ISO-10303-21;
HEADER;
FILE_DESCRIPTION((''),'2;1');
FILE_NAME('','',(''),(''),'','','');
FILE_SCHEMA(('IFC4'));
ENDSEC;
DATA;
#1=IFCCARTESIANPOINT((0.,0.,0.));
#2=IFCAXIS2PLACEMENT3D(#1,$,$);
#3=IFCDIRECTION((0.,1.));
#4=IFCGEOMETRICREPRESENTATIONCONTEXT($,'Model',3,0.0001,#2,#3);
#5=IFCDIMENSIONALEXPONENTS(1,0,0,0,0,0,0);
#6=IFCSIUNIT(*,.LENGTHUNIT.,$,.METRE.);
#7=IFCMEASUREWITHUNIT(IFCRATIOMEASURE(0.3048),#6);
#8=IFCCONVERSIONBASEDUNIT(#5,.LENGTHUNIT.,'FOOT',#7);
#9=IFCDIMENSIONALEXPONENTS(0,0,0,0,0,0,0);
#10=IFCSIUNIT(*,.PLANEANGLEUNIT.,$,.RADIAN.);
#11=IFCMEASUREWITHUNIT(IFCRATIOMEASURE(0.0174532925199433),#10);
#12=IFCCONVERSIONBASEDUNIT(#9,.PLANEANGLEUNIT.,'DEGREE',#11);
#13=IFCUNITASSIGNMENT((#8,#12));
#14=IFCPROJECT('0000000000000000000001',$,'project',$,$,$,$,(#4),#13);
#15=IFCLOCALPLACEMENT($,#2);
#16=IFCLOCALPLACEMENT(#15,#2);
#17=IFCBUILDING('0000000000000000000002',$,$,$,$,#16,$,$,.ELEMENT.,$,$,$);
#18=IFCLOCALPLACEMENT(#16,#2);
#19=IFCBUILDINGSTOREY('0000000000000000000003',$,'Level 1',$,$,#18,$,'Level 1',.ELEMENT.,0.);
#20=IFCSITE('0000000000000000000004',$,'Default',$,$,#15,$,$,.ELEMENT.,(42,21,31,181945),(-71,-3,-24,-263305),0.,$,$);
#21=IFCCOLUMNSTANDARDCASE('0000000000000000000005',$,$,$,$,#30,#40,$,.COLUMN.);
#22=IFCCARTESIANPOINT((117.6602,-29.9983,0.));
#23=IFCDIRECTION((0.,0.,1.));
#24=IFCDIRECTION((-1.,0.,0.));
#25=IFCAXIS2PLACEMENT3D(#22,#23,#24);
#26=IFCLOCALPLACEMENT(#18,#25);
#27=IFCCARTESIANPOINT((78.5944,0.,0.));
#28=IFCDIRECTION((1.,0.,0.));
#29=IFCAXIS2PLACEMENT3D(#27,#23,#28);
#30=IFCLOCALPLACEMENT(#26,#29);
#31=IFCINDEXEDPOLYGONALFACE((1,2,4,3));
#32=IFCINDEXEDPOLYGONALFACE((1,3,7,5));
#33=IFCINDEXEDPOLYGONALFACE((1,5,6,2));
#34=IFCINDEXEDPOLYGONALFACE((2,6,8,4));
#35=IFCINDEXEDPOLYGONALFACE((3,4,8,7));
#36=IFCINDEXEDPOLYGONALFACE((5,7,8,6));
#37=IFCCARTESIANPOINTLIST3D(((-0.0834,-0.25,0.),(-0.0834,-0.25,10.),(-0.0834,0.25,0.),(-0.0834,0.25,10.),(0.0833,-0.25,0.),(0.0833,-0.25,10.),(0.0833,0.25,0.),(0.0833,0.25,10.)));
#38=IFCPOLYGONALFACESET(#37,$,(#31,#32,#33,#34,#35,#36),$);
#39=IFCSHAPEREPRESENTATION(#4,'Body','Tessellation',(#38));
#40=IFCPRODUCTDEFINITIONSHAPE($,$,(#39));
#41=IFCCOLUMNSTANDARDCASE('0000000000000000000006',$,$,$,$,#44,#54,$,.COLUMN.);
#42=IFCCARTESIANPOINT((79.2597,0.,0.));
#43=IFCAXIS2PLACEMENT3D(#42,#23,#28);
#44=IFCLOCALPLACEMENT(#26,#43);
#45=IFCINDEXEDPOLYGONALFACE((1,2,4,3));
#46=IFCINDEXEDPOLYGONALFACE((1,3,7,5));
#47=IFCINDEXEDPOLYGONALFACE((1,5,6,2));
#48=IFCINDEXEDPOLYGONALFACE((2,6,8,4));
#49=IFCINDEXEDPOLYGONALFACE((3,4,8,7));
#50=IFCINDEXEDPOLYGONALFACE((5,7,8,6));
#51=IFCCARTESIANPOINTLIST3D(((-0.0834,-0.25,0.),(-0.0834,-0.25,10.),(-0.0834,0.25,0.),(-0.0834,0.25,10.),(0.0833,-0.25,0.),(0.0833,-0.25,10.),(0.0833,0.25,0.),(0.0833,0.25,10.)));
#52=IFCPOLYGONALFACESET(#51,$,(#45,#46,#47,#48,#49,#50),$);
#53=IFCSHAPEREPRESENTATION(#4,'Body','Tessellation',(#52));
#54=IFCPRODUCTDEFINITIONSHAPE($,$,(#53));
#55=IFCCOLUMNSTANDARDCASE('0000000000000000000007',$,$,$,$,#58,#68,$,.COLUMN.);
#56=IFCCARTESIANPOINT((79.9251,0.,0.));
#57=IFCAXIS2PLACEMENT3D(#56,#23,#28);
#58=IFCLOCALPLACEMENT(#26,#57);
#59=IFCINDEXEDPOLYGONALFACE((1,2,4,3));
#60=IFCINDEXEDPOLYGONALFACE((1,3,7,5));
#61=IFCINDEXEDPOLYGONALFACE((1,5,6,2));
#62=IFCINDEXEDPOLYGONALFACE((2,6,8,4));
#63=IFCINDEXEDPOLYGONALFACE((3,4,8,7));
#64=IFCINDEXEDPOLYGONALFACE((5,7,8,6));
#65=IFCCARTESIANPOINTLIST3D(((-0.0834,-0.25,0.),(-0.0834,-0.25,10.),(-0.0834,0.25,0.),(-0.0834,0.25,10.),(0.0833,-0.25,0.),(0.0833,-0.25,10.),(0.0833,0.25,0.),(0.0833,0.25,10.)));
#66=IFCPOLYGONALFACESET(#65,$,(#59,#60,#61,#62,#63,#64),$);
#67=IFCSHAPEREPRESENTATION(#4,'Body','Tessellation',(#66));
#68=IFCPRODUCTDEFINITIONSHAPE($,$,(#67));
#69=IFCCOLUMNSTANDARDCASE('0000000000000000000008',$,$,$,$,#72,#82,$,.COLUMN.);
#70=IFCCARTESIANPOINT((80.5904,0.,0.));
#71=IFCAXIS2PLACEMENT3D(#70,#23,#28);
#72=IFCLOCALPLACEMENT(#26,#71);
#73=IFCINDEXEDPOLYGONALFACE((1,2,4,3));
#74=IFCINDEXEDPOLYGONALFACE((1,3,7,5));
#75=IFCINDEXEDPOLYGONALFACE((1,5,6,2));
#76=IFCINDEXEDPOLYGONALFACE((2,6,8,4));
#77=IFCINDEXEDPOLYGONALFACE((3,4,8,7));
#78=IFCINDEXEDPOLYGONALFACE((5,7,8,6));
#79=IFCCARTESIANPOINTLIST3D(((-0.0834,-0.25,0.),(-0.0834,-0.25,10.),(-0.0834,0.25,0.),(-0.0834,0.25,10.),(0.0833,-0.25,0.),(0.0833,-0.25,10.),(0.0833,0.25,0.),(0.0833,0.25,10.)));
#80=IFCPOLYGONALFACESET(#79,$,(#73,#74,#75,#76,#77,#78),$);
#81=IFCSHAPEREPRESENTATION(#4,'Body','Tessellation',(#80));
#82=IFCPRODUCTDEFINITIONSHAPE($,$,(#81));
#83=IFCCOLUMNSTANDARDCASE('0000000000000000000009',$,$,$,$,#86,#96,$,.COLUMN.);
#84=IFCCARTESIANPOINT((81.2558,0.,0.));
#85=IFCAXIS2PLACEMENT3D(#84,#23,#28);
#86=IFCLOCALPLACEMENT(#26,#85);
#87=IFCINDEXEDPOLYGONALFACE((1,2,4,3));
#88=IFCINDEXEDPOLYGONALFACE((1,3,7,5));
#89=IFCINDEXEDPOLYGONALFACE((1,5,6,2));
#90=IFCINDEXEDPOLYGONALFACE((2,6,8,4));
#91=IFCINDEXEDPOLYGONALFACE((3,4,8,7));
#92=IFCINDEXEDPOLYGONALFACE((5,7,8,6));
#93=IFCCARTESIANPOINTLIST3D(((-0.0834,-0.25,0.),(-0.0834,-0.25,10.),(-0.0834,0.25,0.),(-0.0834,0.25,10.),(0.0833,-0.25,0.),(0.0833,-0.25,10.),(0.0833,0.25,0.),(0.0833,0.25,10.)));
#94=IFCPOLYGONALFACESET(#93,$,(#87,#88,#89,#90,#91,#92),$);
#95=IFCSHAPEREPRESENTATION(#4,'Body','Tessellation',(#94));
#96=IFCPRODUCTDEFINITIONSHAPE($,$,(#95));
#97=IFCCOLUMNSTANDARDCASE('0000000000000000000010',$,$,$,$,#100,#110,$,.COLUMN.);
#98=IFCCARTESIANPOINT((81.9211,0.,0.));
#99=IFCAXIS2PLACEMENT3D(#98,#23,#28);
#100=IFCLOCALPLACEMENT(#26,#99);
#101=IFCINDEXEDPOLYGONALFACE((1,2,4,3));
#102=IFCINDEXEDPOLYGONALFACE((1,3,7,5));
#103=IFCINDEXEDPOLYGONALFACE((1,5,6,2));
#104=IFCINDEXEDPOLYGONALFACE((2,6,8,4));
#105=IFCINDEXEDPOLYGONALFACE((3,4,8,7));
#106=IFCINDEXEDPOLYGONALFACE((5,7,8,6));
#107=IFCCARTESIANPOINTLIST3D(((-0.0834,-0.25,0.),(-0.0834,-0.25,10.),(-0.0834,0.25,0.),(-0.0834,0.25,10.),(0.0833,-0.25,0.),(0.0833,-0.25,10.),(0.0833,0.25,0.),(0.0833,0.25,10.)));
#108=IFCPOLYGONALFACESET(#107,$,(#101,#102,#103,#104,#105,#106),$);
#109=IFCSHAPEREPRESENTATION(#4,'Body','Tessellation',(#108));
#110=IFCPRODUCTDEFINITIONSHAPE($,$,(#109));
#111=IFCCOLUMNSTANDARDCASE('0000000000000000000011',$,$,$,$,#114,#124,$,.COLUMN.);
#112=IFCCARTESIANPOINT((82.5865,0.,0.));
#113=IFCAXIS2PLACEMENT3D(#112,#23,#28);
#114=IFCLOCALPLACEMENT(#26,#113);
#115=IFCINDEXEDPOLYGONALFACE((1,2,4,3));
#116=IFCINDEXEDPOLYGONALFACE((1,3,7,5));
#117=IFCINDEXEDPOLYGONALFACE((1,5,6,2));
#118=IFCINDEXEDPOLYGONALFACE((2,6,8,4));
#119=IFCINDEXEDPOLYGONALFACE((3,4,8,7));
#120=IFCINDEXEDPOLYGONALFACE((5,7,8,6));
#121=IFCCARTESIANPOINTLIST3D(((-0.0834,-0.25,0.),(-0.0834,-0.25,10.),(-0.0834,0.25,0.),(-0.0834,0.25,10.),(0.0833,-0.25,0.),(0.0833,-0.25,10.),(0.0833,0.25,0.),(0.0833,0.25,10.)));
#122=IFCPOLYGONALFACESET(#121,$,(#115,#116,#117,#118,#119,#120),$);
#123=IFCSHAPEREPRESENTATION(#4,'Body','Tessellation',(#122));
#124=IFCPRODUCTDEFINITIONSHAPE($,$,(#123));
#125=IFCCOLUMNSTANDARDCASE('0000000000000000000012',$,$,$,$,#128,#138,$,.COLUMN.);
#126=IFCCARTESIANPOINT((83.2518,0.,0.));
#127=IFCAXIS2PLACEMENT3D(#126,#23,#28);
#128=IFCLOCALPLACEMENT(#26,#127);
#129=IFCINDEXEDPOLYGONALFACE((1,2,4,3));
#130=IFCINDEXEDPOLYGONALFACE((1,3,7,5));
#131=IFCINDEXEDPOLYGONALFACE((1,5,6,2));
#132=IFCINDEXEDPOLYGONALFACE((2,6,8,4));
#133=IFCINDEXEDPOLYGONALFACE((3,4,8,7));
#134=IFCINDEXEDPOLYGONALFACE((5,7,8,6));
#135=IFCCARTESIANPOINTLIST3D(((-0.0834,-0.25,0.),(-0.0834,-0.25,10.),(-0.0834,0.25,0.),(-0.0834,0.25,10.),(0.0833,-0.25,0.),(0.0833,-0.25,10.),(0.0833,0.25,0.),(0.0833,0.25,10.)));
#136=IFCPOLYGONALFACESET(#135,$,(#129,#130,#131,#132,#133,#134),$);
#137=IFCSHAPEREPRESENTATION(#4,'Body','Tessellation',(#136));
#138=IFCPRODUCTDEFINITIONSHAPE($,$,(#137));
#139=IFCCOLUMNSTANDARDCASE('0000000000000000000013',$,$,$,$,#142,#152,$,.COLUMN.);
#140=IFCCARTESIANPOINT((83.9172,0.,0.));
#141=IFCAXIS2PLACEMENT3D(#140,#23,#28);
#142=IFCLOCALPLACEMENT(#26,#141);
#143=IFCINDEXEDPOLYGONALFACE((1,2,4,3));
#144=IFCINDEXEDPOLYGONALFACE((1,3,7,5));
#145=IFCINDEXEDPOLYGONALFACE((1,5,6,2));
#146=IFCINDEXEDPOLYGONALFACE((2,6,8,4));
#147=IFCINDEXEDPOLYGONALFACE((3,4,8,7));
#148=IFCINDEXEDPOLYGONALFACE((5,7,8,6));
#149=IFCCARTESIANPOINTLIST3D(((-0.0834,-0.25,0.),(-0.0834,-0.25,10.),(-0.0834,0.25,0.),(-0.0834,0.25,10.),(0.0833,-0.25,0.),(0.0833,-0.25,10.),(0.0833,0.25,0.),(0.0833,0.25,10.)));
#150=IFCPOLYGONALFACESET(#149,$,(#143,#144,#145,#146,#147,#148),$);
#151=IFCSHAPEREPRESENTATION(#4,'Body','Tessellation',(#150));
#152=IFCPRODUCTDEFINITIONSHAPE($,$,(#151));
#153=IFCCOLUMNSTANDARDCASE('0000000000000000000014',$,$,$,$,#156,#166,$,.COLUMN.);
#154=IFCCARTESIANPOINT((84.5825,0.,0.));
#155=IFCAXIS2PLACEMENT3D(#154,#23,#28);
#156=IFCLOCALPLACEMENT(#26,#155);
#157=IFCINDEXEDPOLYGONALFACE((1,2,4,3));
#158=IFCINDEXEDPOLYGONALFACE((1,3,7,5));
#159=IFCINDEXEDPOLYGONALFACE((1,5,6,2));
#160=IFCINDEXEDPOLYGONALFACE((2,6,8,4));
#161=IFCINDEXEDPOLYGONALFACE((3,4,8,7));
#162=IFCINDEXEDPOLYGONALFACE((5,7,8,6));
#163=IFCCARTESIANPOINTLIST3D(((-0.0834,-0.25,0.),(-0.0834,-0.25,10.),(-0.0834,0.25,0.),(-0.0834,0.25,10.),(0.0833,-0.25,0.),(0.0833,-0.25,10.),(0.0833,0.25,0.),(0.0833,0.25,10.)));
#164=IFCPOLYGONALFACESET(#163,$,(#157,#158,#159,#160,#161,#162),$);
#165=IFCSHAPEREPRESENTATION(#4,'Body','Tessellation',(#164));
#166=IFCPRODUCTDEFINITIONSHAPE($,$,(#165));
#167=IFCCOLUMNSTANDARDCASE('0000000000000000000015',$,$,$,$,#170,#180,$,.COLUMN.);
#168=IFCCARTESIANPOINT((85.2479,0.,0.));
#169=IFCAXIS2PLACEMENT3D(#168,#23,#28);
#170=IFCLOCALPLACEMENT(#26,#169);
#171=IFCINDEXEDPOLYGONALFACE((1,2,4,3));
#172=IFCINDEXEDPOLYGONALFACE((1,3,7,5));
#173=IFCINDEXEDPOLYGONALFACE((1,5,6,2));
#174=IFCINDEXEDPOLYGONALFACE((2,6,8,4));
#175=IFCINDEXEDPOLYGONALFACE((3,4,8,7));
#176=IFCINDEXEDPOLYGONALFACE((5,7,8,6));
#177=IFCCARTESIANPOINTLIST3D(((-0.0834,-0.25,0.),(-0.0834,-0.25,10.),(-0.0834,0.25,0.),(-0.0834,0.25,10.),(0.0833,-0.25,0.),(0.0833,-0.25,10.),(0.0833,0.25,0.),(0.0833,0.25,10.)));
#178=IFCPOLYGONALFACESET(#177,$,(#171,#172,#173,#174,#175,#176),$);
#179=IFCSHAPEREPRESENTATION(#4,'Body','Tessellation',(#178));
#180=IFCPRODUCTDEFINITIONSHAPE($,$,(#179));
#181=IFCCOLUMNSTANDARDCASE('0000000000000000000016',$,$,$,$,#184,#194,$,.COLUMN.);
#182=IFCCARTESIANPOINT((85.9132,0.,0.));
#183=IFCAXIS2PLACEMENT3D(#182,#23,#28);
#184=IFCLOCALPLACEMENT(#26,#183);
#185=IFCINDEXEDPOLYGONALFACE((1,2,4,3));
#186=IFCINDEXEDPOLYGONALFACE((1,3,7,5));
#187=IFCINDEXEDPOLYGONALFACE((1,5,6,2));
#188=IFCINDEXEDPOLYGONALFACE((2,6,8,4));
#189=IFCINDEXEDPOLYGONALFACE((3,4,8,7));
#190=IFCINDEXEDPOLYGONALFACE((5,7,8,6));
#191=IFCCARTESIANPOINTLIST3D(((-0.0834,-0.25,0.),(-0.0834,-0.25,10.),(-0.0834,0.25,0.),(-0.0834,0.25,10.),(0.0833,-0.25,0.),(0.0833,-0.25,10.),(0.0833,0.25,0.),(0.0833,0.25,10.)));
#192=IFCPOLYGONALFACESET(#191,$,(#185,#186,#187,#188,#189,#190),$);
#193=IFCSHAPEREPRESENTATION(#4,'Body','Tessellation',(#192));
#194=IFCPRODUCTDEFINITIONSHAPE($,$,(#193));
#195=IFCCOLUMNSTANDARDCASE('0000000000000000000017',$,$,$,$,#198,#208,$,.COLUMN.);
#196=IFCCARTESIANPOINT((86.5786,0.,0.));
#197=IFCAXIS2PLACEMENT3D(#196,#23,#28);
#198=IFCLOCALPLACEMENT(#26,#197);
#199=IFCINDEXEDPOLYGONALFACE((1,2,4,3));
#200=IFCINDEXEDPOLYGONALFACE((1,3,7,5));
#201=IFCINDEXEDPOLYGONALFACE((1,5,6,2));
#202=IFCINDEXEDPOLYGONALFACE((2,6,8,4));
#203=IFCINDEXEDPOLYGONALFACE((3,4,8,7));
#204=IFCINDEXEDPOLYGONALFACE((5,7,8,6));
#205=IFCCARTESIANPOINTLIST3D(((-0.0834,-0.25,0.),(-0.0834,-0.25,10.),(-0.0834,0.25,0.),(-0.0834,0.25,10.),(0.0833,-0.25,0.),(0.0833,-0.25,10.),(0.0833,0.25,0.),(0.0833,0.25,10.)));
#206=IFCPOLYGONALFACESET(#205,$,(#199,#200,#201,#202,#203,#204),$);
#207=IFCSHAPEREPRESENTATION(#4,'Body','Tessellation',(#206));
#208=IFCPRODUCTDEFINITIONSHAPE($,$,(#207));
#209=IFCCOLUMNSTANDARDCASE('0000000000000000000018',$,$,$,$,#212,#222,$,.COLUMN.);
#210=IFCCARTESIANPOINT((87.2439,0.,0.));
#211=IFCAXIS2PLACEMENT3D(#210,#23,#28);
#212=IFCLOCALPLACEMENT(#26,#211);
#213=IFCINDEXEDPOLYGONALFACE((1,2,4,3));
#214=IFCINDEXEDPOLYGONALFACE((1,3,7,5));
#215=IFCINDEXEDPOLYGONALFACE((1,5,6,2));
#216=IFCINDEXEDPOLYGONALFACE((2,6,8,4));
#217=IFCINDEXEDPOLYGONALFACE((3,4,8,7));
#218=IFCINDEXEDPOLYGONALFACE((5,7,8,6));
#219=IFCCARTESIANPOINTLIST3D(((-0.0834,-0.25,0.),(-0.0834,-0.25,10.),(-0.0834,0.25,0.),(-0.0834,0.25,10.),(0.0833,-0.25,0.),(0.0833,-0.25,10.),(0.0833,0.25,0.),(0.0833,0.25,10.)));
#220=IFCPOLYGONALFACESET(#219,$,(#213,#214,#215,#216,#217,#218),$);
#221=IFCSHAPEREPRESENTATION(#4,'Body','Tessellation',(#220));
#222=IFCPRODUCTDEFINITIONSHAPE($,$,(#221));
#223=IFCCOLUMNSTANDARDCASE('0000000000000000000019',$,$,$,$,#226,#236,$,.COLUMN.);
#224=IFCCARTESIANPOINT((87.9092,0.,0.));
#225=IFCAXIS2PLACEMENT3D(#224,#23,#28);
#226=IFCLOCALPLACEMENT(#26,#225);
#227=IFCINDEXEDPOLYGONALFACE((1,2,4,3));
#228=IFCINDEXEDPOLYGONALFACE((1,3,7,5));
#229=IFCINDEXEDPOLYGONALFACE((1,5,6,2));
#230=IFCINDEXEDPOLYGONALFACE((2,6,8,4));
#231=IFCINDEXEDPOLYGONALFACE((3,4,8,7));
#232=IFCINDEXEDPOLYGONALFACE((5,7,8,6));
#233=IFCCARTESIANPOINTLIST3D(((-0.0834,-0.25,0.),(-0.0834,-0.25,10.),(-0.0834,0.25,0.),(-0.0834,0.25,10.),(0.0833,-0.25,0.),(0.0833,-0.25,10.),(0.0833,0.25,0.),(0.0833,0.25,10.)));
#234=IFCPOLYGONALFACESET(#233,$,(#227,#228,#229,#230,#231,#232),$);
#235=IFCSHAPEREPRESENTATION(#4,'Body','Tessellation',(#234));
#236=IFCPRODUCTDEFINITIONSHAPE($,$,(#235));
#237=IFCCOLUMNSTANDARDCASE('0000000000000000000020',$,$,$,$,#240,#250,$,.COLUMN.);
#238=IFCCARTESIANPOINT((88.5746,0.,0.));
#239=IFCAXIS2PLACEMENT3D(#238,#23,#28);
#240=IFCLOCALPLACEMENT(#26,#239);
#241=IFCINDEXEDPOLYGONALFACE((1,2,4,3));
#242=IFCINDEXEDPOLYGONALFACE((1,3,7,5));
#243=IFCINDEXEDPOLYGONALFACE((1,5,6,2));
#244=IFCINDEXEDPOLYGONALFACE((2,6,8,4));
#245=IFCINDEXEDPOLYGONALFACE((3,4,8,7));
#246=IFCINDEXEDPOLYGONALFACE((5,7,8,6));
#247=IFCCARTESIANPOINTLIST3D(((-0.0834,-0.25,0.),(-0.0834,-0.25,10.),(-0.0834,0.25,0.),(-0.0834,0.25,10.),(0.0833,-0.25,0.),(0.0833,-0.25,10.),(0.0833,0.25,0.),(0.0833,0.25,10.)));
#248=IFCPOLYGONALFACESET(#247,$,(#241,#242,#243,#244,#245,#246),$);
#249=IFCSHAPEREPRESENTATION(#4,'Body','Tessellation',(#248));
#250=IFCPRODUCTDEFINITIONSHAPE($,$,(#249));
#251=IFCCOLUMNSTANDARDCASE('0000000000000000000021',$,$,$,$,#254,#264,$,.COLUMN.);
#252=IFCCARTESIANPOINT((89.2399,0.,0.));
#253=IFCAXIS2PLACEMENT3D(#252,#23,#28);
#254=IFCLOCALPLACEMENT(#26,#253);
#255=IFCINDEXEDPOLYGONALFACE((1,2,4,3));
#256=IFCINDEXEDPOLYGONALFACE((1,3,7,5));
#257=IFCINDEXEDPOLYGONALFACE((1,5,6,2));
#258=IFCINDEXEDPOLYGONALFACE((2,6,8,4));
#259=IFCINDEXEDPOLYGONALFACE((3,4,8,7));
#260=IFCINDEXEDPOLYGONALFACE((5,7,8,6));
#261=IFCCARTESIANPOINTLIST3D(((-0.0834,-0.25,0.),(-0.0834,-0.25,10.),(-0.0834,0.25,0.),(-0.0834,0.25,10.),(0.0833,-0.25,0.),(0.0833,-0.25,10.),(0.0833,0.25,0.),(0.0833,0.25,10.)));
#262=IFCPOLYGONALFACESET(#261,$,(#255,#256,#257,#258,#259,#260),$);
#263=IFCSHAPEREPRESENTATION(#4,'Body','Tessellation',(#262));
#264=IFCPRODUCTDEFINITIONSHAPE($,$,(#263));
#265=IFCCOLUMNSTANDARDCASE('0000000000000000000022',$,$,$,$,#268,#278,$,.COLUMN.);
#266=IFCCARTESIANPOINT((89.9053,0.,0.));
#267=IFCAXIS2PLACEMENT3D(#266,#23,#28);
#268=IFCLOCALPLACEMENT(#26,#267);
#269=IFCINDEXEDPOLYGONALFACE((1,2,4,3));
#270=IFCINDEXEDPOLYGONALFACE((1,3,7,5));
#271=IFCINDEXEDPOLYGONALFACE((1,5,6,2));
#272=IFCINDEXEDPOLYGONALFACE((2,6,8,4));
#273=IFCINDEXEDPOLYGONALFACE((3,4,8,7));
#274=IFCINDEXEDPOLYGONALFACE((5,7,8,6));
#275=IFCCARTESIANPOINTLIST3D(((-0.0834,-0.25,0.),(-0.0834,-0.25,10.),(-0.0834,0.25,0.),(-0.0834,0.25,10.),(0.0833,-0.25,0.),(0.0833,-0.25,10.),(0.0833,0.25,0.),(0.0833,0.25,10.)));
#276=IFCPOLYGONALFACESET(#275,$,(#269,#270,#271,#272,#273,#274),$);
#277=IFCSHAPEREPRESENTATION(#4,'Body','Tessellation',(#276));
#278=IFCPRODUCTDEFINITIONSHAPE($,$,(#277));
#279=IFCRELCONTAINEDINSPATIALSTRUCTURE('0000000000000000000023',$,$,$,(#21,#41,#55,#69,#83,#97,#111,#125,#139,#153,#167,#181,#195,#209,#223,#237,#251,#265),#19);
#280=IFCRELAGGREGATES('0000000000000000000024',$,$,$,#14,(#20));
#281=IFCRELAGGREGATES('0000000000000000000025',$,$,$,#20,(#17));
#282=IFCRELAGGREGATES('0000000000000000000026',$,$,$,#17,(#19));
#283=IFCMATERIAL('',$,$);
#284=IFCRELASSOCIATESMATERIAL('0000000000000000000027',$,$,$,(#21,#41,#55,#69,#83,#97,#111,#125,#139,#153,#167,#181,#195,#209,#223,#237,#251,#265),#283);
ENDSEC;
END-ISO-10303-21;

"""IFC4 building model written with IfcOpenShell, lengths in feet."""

from ifc_helpers import new_model, entity, si_unit, converted_unit, direction, frame, origin, place, context, project, spatial, rectangle, extrude, material, element, save


model = new_model("IFC4")

# Units and contexts
model_context = context("Model", 3, precision=0.0001, world=origin(), true_north=direction((0.0, 1.0)))
ifc_project = project(units=[converted_unit("LENGTHUNIT", "FOOT", entity("IfcRatioMeasure", 0.3048), si_unit("LENGTHUNIT", "METRE"), dimensions=[1, 0, 0, 0, 0, 0, 0]), converted_unit("PLANEANGLEUNIT", "DEGREE", entity("IfcRatioMeasure", 0.0174532925199433), si_unit("PLANEANGLEUNIT", "RADIAN"), dimensions=[0, 0, 0, 0, 0, 0, 0])], contexts=[model_context])

# Site, building, storey
site_placement = place(None, origin())
site = spatial("IfcSite", under=ifc_project, at=site_placement, Name="Default", CompositionType="ELEMENT", RefLatitude=(42, 21, 31, 181945), RefLongitude=(-71, -3, -24, -263305), RefElevation=0.0)
building_placement = place(site_placement, origin())
building = spatial("IfcBuilding", under=site, at=building_placement, CompositionType="ELEMENT")
storey_placement = place(building_placement, origin())
storey = spatial("IfcBuildingStorey", under=building, at=storey_placement, Name="Level 1", LongName="Level 1", CompositionType="ELEMENT", Elevation=0.0)

# Columns
ifc_material_1 = material(Name="")
placement = place(storey_placement, frame((117.6602, -29.9983, 0.0), z_axis=(0.0, 0.0, 1.0), x_axis=(-1.0, 0.0, 0.0)))
for number, where, z_axis, x_axis in (
    (1, (78.5944, 0.0, 0.0), (0.0, 0.0, 1.0), (1.0, 0.0, 0.0)),
    (2, (79.2597, 0.0, 0.0), (0.0, 0.0, 1.0), (1.0, 0.0, 0.0)),
    (3, (79.9251, 0.0, 0.0), (0.0, 0.0, 1.0), (1.0, 0.0, 0.0)),
    (4, (80.5904, 0.0, 0.0), (0.0, 0.0, 1.0), (1.0, 0.0, 0.0)),
    (5, (81.2558, 0.0, 0.0), (0.0, 0.0, 1.0), (1.0, 0.0, 0.0)),
    (6, (81.9211, 0.0, 0.0), (0.0, 0.0, 1.0), (1.0, 0.0, 0.0)),
    (7, (82.5865, 0.0, 0.0), (0.0, 0.0, 1.0), (1.0, 0.0, 0.0)),
    (8, (83.2518, 0.0, 0.0), (0.0, 0.0, 1.0), (1.0, 0.0, 0.0)),
    (9, (83.9172, 0.0, 0.0), (0.0, 0.0, 1.0), (1.0, 0.0, 0.0)),
    (10, (84.5825, 0.0, 0.0), (0.0, 0.0, 1.0), (1.0, 0.0, 0.0)),
    (11, (85.2479, 0.0, 0.0), (0.0, 0.0, 1.0), (1.0, 0.0, 0.0)),
    (12, (85.9132, 0.0, 0.0), (0.0, 0.0, 1.0), (1.0, 0.0, 0.0)),
    (13, (86.5786, 0.0, 0.0), (0.0, 0.0, 1.0), (1.0, 0.0, 0.0)),
    (14, (87.2439, 0.0, 0.0), (0.0, 0.0, 1.0), (1.0, 0.0, 0.0)),
    (15, (87.9092, 0.0, 0.0), (0.0, 0.0, 1.0), (1.0, 0.0, 0.0)),
    (16, (88.5746, 0.0, 0.0), (0.0, 0.0, 1.0), (1.0, 0.0, 0.0)),
    (17, (89.2399, 0.0, 0.0), (0.0, 0.0, 1.0), (1.0, 0.0, 0.0)),
    (18, (89.9053, 0.0, 0.0), (0.0, 0.0, 1.0), (1.0, 0.0, 0.0)),
):
    element("IfcColumnStandardCase", number, at=place(placement, frame(where, z_axis=z_axis, x_axis=x_axis)), inside=storey, material=ifc_material_1, PredefinedType="COLUMN", context=model_context, shape_type="SweptSolid", body=[
        extrude(rectangle(XDim=0.1667, YDim=0.5), origin(), (0.0, 0.0, 1.0), 10.0),
    ])

save(model, "model.ifc")
